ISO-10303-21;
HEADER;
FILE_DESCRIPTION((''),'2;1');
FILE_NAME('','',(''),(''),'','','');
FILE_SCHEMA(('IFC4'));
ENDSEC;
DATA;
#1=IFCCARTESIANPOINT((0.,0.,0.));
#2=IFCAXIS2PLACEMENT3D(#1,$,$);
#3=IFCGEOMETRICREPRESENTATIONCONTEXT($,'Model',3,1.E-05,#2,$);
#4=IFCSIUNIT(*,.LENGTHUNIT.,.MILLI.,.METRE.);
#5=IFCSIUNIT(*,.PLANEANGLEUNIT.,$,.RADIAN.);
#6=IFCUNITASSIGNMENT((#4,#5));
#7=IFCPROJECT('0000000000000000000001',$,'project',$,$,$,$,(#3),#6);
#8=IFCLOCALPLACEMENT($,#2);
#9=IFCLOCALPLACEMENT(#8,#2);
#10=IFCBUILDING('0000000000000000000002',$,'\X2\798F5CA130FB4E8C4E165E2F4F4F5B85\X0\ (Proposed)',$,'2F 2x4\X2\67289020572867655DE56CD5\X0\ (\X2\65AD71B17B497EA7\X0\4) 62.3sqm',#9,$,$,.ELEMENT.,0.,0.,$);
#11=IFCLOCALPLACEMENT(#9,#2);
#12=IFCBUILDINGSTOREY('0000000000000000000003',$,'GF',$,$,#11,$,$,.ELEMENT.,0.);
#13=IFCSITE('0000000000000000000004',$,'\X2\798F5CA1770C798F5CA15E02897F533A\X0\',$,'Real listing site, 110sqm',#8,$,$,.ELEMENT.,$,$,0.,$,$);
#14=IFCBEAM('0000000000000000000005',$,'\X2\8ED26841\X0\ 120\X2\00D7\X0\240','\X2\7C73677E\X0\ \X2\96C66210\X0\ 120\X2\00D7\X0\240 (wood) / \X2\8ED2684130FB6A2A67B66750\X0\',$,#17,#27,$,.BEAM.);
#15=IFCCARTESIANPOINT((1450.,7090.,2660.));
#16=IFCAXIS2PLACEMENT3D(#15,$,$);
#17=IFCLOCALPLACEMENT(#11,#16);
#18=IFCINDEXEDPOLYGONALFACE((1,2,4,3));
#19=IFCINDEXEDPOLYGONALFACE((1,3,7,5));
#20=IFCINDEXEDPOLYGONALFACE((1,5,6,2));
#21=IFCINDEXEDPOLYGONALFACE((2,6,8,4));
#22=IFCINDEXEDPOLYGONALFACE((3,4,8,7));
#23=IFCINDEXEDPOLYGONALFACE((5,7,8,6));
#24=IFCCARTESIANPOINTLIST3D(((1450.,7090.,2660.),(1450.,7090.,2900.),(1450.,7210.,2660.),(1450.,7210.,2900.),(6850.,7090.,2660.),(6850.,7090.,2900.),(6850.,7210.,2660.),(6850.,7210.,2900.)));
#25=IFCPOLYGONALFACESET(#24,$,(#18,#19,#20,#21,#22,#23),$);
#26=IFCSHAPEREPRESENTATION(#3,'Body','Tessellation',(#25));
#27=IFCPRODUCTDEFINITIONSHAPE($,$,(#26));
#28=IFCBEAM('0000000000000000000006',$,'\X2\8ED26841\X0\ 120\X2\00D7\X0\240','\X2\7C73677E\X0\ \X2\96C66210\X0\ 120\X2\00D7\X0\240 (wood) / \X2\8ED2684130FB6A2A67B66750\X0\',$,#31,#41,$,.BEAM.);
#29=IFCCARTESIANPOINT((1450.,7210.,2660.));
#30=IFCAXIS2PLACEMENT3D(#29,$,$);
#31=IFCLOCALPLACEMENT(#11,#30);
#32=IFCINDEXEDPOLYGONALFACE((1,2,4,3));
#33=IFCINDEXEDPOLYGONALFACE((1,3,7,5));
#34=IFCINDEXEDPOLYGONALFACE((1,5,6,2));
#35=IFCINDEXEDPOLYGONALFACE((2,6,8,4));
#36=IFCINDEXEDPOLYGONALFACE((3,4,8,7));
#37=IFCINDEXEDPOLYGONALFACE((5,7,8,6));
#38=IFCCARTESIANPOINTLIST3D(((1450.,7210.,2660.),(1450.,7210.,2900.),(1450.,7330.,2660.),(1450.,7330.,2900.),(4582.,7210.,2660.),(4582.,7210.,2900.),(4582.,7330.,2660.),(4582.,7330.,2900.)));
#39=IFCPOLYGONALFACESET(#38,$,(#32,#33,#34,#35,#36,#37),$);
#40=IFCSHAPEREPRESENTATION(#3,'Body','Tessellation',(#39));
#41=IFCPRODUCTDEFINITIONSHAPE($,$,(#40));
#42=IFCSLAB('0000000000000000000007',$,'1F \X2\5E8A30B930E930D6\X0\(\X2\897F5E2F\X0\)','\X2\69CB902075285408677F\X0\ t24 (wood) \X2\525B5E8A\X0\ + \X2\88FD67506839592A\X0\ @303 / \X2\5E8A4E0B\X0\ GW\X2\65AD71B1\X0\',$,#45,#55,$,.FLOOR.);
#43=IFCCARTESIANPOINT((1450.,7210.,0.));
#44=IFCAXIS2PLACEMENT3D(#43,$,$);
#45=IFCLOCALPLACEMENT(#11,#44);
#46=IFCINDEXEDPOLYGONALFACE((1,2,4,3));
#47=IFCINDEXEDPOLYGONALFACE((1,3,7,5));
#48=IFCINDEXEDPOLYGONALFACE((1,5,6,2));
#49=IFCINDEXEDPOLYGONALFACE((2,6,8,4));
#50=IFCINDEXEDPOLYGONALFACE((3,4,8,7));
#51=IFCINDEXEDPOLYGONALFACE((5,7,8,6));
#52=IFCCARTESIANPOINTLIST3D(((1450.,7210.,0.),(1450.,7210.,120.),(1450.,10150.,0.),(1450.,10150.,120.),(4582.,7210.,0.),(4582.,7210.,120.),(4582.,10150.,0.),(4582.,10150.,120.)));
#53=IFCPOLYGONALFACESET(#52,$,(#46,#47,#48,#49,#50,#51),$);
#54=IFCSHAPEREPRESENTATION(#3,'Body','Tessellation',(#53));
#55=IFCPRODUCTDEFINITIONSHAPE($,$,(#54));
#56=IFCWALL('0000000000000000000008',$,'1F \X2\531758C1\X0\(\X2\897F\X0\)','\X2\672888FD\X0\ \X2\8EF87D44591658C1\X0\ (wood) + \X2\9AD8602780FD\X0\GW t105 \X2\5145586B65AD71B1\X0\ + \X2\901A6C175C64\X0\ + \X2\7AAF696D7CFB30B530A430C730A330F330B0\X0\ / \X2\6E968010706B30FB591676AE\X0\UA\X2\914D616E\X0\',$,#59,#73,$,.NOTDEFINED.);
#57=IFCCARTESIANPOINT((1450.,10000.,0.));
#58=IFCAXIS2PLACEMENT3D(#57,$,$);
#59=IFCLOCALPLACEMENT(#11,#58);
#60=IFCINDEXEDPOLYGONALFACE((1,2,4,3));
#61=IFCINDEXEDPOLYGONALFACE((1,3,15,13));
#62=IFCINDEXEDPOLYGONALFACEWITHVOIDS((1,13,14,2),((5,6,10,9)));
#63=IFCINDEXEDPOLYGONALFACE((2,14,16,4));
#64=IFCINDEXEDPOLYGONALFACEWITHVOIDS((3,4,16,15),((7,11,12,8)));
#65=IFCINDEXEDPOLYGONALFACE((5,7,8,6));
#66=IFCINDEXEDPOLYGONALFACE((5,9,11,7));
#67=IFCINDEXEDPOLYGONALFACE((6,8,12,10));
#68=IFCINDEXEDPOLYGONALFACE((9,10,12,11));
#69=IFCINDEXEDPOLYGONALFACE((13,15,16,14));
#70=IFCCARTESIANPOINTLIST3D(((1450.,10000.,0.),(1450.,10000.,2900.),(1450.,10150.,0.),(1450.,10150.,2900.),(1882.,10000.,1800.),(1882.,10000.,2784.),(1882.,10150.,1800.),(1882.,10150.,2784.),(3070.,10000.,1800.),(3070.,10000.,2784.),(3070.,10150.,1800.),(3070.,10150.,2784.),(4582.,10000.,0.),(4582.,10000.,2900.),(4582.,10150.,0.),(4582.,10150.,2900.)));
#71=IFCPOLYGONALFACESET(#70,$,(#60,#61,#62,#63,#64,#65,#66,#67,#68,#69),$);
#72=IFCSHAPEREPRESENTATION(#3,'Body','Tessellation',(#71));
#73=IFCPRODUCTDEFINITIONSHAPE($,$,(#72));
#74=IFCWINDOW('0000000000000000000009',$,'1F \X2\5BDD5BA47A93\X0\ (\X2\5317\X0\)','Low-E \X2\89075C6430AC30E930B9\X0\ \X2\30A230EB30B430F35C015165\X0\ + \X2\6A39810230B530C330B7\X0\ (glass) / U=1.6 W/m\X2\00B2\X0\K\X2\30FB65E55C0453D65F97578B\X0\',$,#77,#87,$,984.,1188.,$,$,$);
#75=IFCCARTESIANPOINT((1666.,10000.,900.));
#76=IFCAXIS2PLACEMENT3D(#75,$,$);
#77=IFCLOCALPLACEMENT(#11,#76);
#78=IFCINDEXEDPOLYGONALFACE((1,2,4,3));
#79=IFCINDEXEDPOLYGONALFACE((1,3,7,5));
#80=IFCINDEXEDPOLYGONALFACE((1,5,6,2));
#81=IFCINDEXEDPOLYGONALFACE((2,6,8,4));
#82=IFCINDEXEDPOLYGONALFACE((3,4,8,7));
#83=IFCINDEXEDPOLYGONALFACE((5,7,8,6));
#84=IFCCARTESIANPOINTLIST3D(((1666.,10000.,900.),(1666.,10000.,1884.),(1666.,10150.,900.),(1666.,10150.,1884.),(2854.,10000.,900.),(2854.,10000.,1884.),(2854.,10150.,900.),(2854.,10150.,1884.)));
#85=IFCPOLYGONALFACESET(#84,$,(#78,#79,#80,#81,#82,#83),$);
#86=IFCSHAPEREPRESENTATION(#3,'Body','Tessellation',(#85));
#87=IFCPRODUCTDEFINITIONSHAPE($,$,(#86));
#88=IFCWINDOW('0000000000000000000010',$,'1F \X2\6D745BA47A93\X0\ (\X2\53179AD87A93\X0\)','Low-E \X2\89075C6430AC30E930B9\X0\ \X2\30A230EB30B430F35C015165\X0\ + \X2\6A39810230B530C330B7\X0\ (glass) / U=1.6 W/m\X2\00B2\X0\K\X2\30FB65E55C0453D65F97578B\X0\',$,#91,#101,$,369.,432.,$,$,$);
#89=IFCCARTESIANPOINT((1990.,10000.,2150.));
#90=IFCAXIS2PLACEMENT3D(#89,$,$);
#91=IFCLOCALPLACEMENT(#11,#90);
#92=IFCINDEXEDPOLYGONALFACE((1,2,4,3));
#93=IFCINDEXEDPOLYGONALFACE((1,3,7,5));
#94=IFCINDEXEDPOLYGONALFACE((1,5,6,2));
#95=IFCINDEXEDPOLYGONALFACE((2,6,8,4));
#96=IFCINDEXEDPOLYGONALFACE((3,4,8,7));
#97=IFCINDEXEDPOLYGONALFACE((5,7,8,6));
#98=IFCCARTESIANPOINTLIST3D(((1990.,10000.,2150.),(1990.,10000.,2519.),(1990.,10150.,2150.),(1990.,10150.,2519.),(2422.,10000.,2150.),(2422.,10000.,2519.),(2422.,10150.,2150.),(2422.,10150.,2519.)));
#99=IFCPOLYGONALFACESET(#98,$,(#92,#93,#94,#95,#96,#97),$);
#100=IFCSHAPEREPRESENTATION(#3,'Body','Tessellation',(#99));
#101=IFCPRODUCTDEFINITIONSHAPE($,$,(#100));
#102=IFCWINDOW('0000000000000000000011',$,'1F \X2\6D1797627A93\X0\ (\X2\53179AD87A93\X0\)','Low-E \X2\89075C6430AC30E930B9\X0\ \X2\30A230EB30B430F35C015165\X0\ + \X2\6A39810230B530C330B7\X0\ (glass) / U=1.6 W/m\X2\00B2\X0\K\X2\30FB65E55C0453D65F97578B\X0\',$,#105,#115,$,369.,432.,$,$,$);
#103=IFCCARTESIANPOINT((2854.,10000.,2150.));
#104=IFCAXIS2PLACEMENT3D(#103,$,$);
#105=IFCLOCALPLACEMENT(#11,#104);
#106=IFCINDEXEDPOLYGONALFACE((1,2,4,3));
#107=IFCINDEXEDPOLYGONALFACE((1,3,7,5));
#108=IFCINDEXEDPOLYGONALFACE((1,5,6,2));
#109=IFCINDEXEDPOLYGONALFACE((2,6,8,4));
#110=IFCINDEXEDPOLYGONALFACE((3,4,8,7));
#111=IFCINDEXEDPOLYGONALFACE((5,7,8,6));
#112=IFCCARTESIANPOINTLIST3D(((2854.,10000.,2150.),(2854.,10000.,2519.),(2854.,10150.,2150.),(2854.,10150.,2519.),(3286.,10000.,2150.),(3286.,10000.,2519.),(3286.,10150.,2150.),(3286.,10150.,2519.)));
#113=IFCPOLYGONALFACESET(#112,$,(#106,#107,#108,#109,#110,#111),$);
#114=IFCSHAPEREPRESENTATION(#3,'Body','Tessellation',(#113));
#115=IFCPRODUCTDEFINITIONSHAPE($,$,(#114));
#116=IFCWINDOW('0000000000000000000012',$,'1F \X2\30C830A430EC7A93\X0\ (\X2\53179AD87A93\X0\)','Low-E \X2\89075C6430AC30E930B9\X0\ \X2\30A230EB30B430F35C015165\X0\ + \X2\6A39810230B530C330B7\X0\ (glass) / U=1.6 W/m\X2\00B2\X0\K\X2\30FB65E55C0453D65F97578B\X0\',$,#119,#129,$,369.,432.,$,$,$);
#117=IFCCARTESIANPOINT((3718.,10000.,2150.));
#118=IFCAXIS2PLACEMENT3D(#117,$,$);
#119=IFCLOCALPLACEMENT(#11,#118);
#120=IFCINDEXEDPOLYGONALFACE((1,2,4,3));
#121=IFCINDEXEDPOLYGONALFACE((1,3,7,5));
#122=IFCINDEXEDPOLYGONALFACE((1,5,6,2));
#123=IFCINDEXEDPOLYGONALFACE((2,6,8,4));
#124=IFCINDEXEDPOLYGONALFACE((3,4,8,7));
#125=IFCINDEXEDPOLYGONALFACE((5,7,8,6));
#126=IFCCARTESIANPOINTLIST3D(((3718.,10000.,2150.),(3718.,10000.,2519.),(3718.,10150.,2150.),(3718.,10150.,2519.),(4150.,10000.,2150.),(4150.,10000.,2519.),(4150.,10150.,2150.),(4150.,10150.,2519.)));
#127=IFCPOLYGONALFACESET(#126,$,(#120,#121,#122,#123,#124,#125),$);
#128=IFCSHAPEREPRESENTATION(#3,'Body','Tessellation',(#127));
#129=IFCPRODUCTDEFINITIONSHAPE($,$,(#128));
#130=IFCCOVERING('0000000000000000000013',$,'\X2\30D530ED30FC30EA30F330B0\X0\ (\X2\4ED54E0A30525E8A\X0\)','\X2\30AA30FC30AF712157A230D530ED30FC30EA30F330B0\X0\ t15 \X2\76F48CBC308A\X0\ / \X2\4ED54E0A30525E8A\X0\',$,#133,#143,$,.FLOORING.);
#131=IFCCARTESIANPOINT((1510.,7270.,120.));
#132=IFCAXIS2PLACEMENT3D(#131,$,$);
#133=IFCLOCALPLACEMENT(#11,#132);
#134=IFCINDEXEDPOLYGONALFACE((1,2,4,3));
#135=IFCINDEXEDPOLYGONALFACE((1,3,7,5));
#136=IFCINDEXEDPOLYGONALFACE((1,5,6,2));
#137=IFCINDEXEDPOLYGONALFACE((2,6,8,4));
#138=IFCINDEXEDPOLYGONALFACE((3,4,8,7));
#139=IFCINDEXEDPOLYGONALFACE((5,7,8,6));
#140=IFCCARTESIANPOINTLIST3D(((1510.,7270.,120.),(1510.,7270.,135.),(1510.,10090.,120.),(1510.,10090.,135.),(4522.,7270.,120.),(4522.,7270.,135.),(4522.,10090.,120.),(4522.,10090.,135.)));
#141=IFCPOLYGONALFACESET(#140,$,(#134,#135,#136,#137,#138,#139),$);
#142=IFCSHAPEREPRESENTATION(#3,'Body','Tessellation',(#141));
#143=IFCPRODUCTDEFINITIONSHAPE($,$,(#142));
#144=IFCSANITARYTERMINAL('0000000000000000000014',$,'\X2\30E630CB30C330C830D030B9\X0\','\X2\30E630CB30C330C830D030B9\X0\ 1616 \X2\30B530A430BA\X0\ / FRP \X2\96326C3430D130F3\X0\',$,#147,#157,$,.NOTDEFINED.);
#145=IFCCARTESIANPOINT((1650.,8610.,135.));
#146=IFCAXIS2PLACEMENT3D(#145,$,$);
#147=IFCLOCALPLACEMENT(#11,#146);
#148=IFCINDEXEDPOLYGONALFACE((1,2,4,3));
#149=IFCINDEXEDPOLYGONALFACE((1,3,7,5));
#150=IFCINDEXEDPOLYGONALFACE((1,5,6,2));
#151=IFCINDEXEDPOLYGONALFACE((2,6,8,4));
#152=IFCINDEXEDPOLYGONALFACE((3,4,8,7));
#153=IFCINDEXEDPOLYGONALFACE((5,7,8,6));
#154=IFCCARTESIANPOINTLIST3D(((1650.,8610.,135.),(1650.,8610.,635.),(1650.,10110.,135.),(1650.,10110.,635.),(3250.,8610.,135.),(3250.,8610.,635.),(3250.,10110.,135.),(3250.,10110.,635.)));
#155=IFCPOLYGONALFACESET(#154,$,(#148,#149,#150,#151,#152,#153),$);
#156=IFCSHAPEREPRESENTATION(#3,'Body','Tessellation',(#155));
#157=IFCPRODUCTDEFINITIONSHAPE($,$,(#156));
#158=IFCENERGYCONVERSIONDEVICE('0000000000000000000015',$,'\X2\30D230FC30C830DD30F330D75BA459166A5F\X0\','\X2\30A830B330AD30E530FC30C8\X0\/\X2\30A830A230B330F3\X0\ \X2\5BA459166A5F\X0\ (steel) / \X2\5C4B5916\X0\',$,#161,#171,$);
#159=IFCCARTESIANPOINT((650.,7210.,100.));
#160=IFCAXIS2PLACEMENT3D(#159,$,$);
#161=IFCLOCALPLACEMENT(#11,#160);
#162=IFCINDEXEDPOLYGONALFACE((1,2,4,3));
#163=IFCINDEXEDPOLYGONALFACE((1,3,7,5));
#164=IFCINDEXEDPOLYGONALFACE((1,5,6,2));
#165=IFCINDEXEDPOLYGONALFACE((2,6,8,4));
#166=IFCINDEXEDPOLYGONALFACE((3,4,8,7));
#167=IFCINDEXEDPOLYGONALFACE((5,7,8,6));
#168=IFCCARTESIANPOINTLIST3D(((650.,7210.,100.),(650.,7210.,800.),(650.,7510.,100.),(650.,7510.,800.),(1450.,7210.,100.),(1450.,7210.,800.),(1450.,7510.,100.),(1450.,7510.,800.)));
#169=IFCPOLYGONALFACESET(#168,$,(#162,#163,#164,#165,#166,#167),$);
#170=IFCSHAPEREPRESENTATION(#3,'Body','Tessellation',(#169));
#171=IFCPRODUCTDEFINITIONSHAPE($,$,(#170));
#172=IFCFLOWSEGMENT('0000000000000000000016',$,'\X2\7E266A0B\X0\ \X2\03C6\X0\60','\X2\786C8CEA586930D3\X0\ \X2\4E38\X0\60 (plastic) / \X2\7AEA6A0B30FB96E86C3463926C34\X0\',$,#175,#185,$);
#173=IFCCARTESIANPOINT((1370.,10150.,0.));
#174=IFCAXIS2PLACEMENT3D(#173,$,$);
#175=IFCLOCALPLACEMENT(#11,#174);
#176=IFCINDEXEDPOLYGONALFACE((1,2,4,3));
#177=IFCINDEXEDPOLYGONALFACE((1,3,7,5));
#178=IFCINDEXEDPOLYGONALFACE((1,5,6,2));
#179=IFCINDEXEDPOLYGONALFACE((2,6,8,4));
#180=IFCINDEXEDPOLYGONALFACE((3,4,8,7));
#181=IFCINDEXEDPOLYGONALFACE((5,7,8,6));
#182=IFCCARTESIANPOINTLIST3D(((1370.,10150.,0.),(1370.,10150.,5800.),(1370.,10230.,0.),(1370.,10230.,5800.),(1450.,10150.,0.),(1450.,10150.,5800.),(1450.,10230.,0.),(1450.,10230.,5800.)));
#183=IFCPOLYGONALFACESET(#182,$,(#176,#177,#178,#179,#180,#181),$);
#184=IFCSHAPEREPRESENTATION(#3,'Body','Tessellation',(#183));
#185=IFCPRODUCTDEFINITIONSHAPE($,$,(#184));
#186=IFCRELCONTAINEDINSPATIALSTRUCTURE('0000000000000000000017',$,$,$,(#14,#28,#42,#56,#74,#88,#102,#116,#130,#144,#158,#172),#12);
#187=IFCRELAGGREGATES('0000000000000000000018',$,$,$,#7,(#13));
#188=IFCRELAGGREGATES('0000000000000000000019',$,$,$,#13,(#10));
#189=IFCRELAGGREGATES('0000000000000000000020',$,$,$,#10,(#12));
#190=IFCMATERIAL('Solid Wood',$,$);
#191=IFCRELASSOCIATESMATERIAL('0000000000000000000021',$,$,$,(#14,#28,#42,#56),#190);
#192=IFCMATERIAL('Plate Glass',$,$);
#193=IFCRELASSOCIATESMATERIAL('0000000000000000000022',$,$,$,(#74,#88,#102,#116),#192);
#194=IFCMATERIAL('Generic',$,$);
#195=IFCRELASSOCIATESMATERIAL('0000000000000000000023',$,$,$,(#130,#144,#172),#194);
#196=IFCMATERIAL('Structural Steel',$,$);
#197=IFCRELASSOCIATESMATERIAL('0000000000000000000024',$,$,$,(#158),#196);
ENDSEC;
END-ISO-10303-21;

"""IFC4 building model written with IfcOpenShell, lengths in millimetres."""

from ifc_helpers import new_model, si_unit, frame, frame_2d, origin, place, context, project, spatial, rectangle, extrude, material, element, fill, save


model = new_model("IFC4")

# Units and contexts
model_context = context("Model", 3, precision=1e-05, world=origin())
ifc_project = project(units=[si_unit("LENGTHUNIT", "METRE", prefix="MILLI"), si_unit("PLANEANGLEUNIT", "RADIAN")], contexts=[model_context])

# Site, building, storey
site_placement = place(None, origin())
site = spatial("IfcSite", under=ifc_project, at=site_placement, Name="福岡県福岡市西区", ObjectType="Real listing site, 110sqm", CompositionType="ELEMENT", RefElevation=0.0)
building_placement = place(site_placement, origin())
building = spatial("IfcBuilding", under=site, at=building_placement, Name="福岡・二世帯住宅 (Proposed)", ObjectType="2F 2x4木造在来工法 (断熱等级4) 62.3sqm", CompositionType="ELEMENT", ElevationOfRefHeight=0.0, ElevationOfTerrain=0.0)
storey_placement = place(building_placement, origin())
storey = spatial("IfcBuildingStorey", under=building, at=storey_placement, Name="GF", CompositionType="ELEMENT", Elevation=0.0)

# Shared definitions
ifc_material_1 = material(Name="Solid Wood")

# Beams
beam_1_placement = place(storey_placement, frame((1450.0, 7090.0, 2660.0)))
element("IfcBeam", 1, at=beam_1_placement, inside=storey, material=ifc_material_1, Name="軒桁 120×240", Description="米松 集成 120×240 (wood) / 軒桁・横架材", PredefinedType="BEAM", context=model_context, shape_type="SweptSolid", body=[
    extrude(rectangle(XDim=5400.0, YDim=120.0, at=frame_2d((2700.0, 60.0))), frame((1450.0, 7090.0, 2660.0)), (0.0, 0.0, 1.0), 240.0),
])
beam_2_placement = place(storey_placement, frame((1450.0, 7210.0, 2660.0)))
element("IfcBeam", 2, at=beam_2_placement, inside=storey, material=ifc_material_1, Name="軒桁 120×240", Description="米松 集成 120×240 (wood) / 軒桁・横架材", PredefinedType="BEAM", context=model_context, shape_type="SweptSolid", body=[
    extrude(rectangle(XDim=3132.0, YDim=120.0, at=frame_2d((1566.0, 60.0))), frame((1450.0, 7210.0, 2660.0)), (0.0, 0.0, 1.0), 240.0),
])

# Slab
slab_placement = place(storey_placement, frame((1450.0, 7210.0, 0.0)))
element("IfcSlab", 3, at=slab_placement, inside=storey, material=ifc_material_1, Name="1F 床スラブ(西帯)", Description="構造用合板 t24 (wood) 剛床 + 製材根太 @303 / 床下 GW断熱", PredefinedType="FLOOR", context=model_context, shape_type="SweptSolid", body=[
    extrude(rectangle(XDim=3132.0, YDim=2940.0, at=frame_2d((1566.0, 1470.0))), frame((1450.0, 7210.0, 0.0)), (0.0, 0.0, 1.0), 120.0),
])

# Wall, openings, windows
wall_1_placement = place(storey_placement, frame((1450.0, 10000.0, 0.0)))
wall_1 = element("IfcWall", 4, at=wall_1_placement, inside=storey, material=ifc_material_1, Name="1F 北壁(西)", Description="木製 軸組外壁 (wood) + 高性能GW t105 充填断熱 + 通気層 + 窯業系サイディング / 準耐火・外皮UA配慮", PredefinedType="NOTDEFINED", context=model_context, shape_type="SweptSolid", body=[
    extrude(rectangle(XDim=3132.0, YDim=150.0, at=frame_2d((1566.0, 75.0))), frame((1450.0, 10000.0, 0.0)), (0.0, 0.0, 1.0), 2900.0),
])
opening_1_placement = place(storey_placement, frame((1666.0, 10000.0, 900.0)))
opening_1 = element("IfcOpeningElement", 5, at=opening_1_placement, cuts=wall_1, PredefinedType="NOTDEFINED", context=model_context, shape_type="SweptSolid", body=[
    extrude(rectangle(XDim=1188.0, YDim=150.0, at=frame_2d((594.0, 75.0))), frame((1666.0, 10000.0, 900.0)), (0.0, 0.0, 1.0), 984.0),
])
opening_2_placement = place(storey_placement, frame((1990.0, 10000.0, 2150.0)))
opening_2 = element("IfcOpeningElement", 6, at=opening_2_placement, cuts=wall_1, PredefinedType="NOTDEFINED", context=model_context, shape_type="SweptSolid", body=[
    extrude(rectangle(XDim=432.0, YDim=150.0, at=frame_2d((216.0, 75.0))), frame((1990.0, 10000.0, 2150.0)), (0.0, 0.0, 1.0), 369.0),
])
opening_3_placement = place(storey_placement, frame((2854.0, 10000.0, 2150.0)))
opening_3 = element("IfcOpeningElement", 7, at=opening_3_placement, cuts=wall_1, PredefinedType="NOTDEFINED", context=model_context, shape_type="SweptSolid", body=[
    extrude(rectangle(XDim=432.0, YDim=150.0, at=frame_2d((216.0, 75.0))), frame((2854.0, 10000.0, 2150.0)), (0.0, 0.0, 1.0), 369.0),
])
opening_4_placement = place(storey_placement, frame((3718.0, 10000.0, 2150.0)))
opening_4 = element("IfcOpeningElement", 8, at=opening_4_placement, cuts=wall_1, PredefinedType="NOTDEFINED", context=model_context, shape_type="SweptSolid", body=[
    extrude(rectangle(XDim=432.0, YDim=150.0, at=frame_2d((216.0, 75.0))), frame((3718.0, 10000.0, 2150.0)), (0.0, 0.0, 1.0), 369.0),
])
ifc_material_2 = material(Name="Plate Glass")
window_1_placement = place(storey_placement, frame((1666.0, 10000.0, 900.0)))
window_1 = element("IfcWindow", 9, at=window_1_placement, inside=storey, material=ifc_material_2, Name="1F 寝室窓 (北)", Description="Low-E 複層ガラス アルゴン封入 + 樹脂サッシ (glass) / U=1.6 W/m²K・日射取得型", OverallHeight=984.0, OverallWidth=1188.0, context=model_context, shape_type="SweptSolid", body=[
    extrude(rectangle(XDim=1188.0, YDim=150.0, at=frame_2d((594.0, 75.0))), frame((1666.0, 10000.0, 900.0)), (0.0, 0.0, 1.0), 984.0),
])
fill(opening_1, window_1)
window_2_placement = place(storey_placement, frame((1990.0, 10000.0, 2150.0)))
window_2 = element("IfcWindow", 10, at=window_2_placement, inside=storey, material=ifc_material_2, Name="1F 浴室窓 (北高窓)", Description="Low-E 複層ガラス アルゴン封入 + 樹脂サッシ (glass) / U=1.6 W/m²K・日射取得型", OverallHeight=369.0, OverallWidth=432.0, context=model_context, shape_type="SweptSolid", body=[
    extrude(rectangle(XDim=432.0, YDim=150.0, at=frame_2d((216.0, 75.0))), frame((1990.0, 10000.0, 2150.0)), (0.0, 0.0, 1.0), 369.0),
])
fill(opening_2, window_2)
window_3_placement = place(storey_placement, frame((2854.0, 10000.0, 2150.0)))
window_3 = element("IfcWindow", 11, at=window_3_placement, inside=storey, material=ifc_material_2, Name="1F 洗面窓 (北高窓)", Description="Low-E 複層ガラス アルゴン封入 + 樹脂サッシ (glass) / U=1.6 W/m²K・日射取得型", OverallHeight=369.0, OverallWidth=432.0, context=model_context, shape_type="SweptSolid", body=[
    extrude(rectangle(XDim=432.0, YDim=150.0, at=frame_2d((216.0, 75.0))), frame((2854.0, 10000.0, 2150.0)), (0.0, 0.0, 1.0), 369.0),
])
fill(opening_3, window_3)
window_4_placement = place(storey_placement, frame((3718.0, 10000.0, 2150.0)))
window_4 = element("IfcWindow", 12, at=window_4_placement, inside=storey, material=ifc_material_2, Name="1F トイレ窓 (北高窓)", Description="Low-E 複層ガラス アルゴン封入 + 樹脂サッシ (glass) / U=1.6 W/m²K・日射取得型", OverallHeight=369.0, OverallWidth=432.0, context=model_context, shape_type="SweptSolid", body=[
    extrude(rectangle(XDim=432.0, YDim=150.0, at=frame_2d((216.0, 75.0))), frame((3718.0, 10000.0, 2150.0)), (0.0, 0.0, 1.0), 369.0),
])
fill(opening_4, window_4)

# Covering
ifc_material_3 = material(Name="Generic")
covering_placement = place(storey_placement, frame((1510.0, 7270.0, 120.0)))
element("IfcCovering", 13, at=covering_placement, inside=storey, material=ifc_material_3, Name="フローリング (仕上げ床)", Description="オーク無垢フローリング t15 直貼り / 仕上げ床", PredefinedType="FLOORING", context=model_context, shape_type="SweptSolid", body=[
    extrude(rectangle(XDim=3012.0, YDim=2820.0, at=frame_2d((1506.0, 1410.0))), frame((1510.0, 7270.0, 120.0)), (0.0, 0.0, 1.0), 15.0),
])

# Sanitary terminal
sanitary_terminal_placement = place(storey_placement, frame((1650.0, 8610.0, 135.0)))
element("IfcSanitaryTerminal", 14, at=sanitary_terminal_placement, inside=storey, material=ifc_material_3, Name="ユニットバス", Description="ユニットバス 1616 サイズ / FRP 防水パン", PredefinedType="NOTDEFINED", context=model_context, shape_type="SweptSolid", body=[
    extrude(rectangle(XDim=1600.0, YDim=1500.0, at=frame_2d((800.0, 750.0))), frame((1650.0, 8610.0, 135.0)), (0.0, 0.0, 1.0), 500.0),
])

# Energy conversion device
ifc_material_4 = material(Name="Structural Steel")
energy_conversion_device_placement = place(storey_placement, frame((650.0, 7210.0, 100.0)))
element("IfcEnergyConversionDevice", 15, at=energy_conversion_device_placement, inside=storey, material=ifc_material_4, Name="ヒートポンプ室外機", Description="エコキュート/エアコン 室外機 (steel) / 屋外", context=model_context, shape_type="SweptSolid", body=[
    extrude(rectangle(XDim=800.0, YDim=300.0, at=frame_2d((400.0, 150.0))), frame((650.0, 7210.0, 100.0)), (0.0, 0.0, 1.0), 700.0),
])

# Flow segment
flow_segment_placement = place(storey_placement, frame((1370.0, 10150.0, 0.0)))
element("IfcFlowSegment", 16, at=flow_segment_placement, inside=storey, material=ifc_material_3, Name="縦樋 φ60", Description="硬質塩ビ 丸60 (plastic) / 竪樋・雨水排水", context=model_context, shape_type="SweptSolid", body=[
    extrude(rectangle(XDim=80.0, YDim=80.0, at=frame_2d((40.0, 40.0))), frame((1370.0, 10150.0, 0.0)), (0.0, 0.0, 1.0), 5800.0),
])

save(model, "model.ifc")
